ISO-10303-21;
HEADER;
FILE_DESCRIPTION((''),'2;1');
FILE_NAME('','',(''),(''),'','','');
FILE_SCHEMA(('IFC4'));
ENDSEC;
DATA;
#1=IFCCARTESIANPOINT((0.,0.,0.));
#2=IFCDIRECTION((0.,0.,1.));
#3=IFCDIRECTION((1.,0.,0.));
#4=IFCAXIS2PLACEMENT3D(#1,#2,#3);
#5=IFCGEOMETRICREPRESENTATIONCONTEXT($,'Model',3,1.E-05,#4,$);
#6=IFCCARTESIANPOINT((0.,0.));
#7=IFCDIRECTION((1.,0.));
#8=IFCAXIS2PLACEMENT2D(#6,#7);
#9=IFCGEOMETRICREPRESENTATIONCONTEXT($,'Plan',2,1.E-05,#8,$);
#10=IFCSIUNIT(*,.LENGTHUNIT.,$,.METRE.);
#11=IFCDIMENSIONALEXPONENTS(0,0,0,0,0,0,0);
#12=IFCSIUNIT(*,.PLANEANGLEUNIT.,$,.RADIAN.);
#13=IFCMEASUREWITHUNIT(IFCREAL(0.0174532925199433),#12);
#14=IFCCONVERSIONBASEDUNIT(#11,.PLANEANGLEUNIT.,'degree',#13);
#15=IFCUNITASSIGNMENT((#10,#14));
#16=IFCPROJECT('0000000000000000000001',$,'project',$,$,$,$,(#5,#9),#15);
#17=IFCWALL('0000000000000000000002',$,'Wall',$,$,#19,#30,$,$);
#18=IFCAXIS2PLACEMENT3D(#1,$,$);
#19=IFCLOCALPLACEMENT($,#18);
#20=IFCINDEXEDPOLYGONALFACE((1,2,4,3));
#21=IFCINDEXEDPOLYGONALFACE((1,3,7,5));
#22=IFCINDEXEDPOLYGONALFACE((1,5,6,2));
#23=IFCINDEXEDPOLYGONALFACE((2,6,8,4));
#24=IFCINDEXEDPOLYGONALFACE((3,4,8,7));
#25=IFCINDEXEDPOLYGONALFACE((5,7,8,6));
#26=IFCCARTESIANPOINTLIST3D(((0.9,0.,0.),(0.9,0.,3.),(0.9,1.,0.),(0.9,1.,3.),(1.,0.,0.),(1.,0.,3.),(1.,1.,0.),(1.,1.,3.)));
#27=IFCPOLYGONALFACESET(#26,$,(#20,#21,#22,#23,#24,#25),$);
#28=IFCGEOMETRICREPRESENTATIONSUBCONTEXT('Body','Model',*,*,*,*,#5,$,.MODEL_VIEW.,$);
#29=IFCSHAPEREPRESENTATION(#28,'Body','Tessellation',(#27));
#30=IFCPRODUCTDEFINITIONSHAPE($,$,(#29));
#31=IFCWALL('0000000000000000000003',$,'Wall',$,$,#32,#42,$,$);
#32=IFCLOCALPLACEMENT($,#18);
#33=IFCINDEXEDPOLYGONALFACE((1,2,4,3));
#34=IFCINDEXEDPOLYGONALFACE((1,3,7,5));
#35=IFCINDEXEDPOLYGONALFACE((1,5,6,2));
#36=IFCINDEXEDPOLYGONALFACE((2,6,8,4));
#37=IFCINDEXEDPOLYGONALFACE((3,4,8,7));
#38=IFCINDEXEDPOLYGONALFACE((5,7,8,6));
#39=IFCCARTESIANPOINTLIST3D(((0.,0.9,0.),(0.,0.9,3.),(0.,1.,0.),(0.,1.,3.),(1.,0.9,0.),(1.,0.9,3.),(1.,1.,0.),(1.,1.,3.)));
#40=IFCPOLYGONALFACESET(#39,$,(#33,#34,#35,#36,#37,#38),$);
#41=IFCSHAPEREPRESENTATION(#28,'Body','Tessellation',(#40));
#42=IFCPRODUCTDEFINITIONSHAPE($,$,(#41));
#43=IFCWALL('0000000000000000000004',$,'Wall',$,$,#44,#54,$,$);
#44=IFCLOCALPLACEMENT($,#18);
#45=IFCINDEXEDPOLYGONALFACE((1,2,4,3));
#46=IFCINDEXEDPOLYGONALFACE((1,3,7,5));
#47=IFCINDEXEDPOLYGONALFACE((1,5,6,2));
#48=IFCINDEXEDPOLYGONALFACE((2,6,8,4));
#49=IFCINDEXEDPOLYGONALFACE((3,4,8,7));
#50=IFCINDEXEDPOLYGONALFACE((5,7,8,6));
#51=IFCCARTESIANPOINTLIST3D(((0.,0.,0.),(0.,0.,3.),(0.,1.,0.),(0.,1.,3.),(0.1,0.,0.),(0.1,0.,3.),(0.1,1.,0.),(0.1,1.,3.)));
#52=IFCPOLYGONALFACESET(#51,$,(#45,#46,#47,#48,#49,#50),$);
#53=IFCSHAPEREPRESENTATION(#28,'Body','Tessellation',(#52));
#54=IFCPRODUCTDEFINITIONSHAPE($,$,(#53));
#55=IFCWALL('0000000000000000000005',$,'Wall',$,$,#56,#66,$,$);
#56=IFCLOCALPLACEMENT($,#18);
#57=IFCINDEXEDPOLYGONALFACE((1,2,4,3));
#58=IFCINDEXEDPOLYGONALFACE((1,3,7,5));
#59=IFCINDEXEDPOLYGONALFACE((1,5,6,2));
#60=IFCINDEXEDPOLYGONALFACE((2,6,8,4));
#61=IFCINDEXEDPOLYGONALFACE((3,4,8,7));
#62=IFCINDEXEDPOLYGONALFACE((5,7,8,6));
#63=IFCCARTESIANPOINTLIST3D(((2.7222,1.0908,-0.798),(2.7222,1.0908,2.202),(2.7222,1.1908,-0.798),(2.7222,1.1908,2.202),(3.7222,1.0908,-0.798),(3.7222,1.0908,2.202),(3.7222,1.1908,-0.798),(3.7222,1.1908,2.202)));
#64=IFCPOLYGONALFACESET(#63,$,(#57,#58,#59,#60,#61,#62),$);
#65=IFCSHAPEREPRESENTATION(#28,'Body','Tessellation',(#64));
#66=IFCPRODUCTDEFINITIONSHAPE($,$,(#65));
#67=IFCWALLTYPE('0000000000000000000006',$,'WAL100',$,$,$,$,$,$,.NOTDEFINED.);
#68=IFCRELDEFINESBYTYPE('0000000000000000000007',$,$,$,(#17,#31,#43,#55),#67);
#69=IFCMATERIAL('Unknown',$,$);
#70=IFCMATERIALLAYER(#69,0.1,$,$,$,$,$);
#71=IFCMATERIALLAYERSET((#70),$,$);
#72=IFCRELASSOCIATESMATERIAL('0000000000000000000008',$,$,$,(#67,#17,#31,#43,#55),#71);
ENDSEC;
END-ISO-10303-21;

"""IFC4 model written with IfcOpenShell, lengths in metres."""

from ifc_helpers import new_model, entity, si_unit, converted_unit, frame, origin_with_axes, origin_2d_with_axis, place, context, subcontext, project, indexed_curve, outline, extrude, material, layer, layer_set, layer_usage, type_object, element, save


model = new_model("IFC4")

# Units and contexts
model_context = context("Model", 3, precision=1e-05, world=origin_with_axes())
plan_context = context("Plan", 2, precision=1e-05, world=origin_2d_with_axis())
body_context = subcontext(model_context, "Body", "Model", "MODEL_VIEW")
ifc_project = project(units=[si_unit("LENGTHUNIT", "METRE"), converted_unit("PLANEANGLEUNIT", "degree", entity("IfcReal", 0.0174532925199433), si_unit("PLANEANGLEUNIT", "RADIAN"), dimensions=[0, 0, 0, 0, 0, 0, 0])], contexts=[model_context, plan_context])

# Walls
ifc_material = material(Name="Unknown")
ifc_layer = layer(ifc_material, 0.1)
ifc_layer_set = layer_set([ifc_layer])
ifc_layer_usage_1 = layer_usage(ifc_layer_set, "AXIS2", "POSITIVE", 0.0)
wall_type = type_object("IfcWallType", Name="WAL100", PredefinedType="NOTDEFINED", material=ifc_layer_set)
wall_1_placement = place(None, frame((1.0, 0.0, 0.0), z_axis=(0.0, 0.0, 1.0), x_axis=(0.0, 1.0, 0.0)))
element("IfcWall", 1, at=wall_1_placement, type_object=wall_type, material=ifc_layer_usage_1, Name="Wall", context=body_context, shape_type="SweptSolid", body=[
    extrude(outline(indexed_curve([(0.0, 0.0), (0.0, 0.1), (1.0, 0.1), (1.0, 0.0), (0.0, 0.0)], self_intersect=False)), origin_with_axes(), (0.0, 0.0, 1.0), 3.0),
])
ifc_layer_usage_2 = layer_usage(ifc_layer_set, "AXIS2", "POSITIVE", 0.0)
wall_2_placement = place(None, frame((1.0, 1.0, 0.0), z_axis=(0.0, 0.0, 1.0), x_axis=(-1.0, 0.0, 0.0)))
element("IfcWall", 2, at=wall_2_placement, type_object=wall_type, material=ifc_layer_usage_2, Name="Wall", context=body_context, shape_type="SweptSolid", body=[
    extrude(outline(indexed_curve([(0.0, 0.0), (0.0, 0.1), (1.0, 0.1), (1.0, 0.0), (0.0, 0.0)], self_intersect=False)), origin_with_axes(), (0.0, 0.0, 1.0), 3.0),
])
ifc_layer_usage_3 = layer_usage(ifc_layer_set, "AXIS2", "POSITIVE", 0.0)
wall_3_placement = place(None, frame((0.0, 1.0, 0.0), z_axis=(0.0, 0.0, 1.0), x_axis=(-0.000001, -1.0, 0.0)))
element("IfcWall", 3, at=wall_3_placement, type_object=wall_type, material=ifc_layer_usage_3, Name="Wall", context=body_context, shape_type="SweptSolid", body=[
    extrude(outline(indexed_curve([(0.0, 0.0), (0.0, 0.1), (1.0, 0.1), (1.0, 0.0), (0.0, 0.0)], self_intersect=False)), origin_with_axes(), (0.0, 0.0, 1.0), 3.0),
])
ifc_layer_usage_4 = layer_usage(ifc_layer_set, "AXIS2", "POSITIVE", 0.0)
wall_4_placement = place(None, frame((2.7222, 1.0908, -0.798), z_axis=(0.0, 0.0, 1.0), x_axis=(1.0, 0.0, 0.0)))
element("IfcWall", 4, at=wall_4_placement, type_object=wall_type, material=ifc_layer_usage_4, Name="Wall", context=body_context, shape_type="SweptSolid", body=[
    extrude(outline(indexed_curve([(0.0, 0.0), (0.0, 0.1), (1.0, 0.1), (1.0, 0.0), (0.0, 0.0)], self_intersect=False)), origin_with_axes(), (0.0, 0.0, 1.0), 3.0),
])

save(model, "model.ifc")
